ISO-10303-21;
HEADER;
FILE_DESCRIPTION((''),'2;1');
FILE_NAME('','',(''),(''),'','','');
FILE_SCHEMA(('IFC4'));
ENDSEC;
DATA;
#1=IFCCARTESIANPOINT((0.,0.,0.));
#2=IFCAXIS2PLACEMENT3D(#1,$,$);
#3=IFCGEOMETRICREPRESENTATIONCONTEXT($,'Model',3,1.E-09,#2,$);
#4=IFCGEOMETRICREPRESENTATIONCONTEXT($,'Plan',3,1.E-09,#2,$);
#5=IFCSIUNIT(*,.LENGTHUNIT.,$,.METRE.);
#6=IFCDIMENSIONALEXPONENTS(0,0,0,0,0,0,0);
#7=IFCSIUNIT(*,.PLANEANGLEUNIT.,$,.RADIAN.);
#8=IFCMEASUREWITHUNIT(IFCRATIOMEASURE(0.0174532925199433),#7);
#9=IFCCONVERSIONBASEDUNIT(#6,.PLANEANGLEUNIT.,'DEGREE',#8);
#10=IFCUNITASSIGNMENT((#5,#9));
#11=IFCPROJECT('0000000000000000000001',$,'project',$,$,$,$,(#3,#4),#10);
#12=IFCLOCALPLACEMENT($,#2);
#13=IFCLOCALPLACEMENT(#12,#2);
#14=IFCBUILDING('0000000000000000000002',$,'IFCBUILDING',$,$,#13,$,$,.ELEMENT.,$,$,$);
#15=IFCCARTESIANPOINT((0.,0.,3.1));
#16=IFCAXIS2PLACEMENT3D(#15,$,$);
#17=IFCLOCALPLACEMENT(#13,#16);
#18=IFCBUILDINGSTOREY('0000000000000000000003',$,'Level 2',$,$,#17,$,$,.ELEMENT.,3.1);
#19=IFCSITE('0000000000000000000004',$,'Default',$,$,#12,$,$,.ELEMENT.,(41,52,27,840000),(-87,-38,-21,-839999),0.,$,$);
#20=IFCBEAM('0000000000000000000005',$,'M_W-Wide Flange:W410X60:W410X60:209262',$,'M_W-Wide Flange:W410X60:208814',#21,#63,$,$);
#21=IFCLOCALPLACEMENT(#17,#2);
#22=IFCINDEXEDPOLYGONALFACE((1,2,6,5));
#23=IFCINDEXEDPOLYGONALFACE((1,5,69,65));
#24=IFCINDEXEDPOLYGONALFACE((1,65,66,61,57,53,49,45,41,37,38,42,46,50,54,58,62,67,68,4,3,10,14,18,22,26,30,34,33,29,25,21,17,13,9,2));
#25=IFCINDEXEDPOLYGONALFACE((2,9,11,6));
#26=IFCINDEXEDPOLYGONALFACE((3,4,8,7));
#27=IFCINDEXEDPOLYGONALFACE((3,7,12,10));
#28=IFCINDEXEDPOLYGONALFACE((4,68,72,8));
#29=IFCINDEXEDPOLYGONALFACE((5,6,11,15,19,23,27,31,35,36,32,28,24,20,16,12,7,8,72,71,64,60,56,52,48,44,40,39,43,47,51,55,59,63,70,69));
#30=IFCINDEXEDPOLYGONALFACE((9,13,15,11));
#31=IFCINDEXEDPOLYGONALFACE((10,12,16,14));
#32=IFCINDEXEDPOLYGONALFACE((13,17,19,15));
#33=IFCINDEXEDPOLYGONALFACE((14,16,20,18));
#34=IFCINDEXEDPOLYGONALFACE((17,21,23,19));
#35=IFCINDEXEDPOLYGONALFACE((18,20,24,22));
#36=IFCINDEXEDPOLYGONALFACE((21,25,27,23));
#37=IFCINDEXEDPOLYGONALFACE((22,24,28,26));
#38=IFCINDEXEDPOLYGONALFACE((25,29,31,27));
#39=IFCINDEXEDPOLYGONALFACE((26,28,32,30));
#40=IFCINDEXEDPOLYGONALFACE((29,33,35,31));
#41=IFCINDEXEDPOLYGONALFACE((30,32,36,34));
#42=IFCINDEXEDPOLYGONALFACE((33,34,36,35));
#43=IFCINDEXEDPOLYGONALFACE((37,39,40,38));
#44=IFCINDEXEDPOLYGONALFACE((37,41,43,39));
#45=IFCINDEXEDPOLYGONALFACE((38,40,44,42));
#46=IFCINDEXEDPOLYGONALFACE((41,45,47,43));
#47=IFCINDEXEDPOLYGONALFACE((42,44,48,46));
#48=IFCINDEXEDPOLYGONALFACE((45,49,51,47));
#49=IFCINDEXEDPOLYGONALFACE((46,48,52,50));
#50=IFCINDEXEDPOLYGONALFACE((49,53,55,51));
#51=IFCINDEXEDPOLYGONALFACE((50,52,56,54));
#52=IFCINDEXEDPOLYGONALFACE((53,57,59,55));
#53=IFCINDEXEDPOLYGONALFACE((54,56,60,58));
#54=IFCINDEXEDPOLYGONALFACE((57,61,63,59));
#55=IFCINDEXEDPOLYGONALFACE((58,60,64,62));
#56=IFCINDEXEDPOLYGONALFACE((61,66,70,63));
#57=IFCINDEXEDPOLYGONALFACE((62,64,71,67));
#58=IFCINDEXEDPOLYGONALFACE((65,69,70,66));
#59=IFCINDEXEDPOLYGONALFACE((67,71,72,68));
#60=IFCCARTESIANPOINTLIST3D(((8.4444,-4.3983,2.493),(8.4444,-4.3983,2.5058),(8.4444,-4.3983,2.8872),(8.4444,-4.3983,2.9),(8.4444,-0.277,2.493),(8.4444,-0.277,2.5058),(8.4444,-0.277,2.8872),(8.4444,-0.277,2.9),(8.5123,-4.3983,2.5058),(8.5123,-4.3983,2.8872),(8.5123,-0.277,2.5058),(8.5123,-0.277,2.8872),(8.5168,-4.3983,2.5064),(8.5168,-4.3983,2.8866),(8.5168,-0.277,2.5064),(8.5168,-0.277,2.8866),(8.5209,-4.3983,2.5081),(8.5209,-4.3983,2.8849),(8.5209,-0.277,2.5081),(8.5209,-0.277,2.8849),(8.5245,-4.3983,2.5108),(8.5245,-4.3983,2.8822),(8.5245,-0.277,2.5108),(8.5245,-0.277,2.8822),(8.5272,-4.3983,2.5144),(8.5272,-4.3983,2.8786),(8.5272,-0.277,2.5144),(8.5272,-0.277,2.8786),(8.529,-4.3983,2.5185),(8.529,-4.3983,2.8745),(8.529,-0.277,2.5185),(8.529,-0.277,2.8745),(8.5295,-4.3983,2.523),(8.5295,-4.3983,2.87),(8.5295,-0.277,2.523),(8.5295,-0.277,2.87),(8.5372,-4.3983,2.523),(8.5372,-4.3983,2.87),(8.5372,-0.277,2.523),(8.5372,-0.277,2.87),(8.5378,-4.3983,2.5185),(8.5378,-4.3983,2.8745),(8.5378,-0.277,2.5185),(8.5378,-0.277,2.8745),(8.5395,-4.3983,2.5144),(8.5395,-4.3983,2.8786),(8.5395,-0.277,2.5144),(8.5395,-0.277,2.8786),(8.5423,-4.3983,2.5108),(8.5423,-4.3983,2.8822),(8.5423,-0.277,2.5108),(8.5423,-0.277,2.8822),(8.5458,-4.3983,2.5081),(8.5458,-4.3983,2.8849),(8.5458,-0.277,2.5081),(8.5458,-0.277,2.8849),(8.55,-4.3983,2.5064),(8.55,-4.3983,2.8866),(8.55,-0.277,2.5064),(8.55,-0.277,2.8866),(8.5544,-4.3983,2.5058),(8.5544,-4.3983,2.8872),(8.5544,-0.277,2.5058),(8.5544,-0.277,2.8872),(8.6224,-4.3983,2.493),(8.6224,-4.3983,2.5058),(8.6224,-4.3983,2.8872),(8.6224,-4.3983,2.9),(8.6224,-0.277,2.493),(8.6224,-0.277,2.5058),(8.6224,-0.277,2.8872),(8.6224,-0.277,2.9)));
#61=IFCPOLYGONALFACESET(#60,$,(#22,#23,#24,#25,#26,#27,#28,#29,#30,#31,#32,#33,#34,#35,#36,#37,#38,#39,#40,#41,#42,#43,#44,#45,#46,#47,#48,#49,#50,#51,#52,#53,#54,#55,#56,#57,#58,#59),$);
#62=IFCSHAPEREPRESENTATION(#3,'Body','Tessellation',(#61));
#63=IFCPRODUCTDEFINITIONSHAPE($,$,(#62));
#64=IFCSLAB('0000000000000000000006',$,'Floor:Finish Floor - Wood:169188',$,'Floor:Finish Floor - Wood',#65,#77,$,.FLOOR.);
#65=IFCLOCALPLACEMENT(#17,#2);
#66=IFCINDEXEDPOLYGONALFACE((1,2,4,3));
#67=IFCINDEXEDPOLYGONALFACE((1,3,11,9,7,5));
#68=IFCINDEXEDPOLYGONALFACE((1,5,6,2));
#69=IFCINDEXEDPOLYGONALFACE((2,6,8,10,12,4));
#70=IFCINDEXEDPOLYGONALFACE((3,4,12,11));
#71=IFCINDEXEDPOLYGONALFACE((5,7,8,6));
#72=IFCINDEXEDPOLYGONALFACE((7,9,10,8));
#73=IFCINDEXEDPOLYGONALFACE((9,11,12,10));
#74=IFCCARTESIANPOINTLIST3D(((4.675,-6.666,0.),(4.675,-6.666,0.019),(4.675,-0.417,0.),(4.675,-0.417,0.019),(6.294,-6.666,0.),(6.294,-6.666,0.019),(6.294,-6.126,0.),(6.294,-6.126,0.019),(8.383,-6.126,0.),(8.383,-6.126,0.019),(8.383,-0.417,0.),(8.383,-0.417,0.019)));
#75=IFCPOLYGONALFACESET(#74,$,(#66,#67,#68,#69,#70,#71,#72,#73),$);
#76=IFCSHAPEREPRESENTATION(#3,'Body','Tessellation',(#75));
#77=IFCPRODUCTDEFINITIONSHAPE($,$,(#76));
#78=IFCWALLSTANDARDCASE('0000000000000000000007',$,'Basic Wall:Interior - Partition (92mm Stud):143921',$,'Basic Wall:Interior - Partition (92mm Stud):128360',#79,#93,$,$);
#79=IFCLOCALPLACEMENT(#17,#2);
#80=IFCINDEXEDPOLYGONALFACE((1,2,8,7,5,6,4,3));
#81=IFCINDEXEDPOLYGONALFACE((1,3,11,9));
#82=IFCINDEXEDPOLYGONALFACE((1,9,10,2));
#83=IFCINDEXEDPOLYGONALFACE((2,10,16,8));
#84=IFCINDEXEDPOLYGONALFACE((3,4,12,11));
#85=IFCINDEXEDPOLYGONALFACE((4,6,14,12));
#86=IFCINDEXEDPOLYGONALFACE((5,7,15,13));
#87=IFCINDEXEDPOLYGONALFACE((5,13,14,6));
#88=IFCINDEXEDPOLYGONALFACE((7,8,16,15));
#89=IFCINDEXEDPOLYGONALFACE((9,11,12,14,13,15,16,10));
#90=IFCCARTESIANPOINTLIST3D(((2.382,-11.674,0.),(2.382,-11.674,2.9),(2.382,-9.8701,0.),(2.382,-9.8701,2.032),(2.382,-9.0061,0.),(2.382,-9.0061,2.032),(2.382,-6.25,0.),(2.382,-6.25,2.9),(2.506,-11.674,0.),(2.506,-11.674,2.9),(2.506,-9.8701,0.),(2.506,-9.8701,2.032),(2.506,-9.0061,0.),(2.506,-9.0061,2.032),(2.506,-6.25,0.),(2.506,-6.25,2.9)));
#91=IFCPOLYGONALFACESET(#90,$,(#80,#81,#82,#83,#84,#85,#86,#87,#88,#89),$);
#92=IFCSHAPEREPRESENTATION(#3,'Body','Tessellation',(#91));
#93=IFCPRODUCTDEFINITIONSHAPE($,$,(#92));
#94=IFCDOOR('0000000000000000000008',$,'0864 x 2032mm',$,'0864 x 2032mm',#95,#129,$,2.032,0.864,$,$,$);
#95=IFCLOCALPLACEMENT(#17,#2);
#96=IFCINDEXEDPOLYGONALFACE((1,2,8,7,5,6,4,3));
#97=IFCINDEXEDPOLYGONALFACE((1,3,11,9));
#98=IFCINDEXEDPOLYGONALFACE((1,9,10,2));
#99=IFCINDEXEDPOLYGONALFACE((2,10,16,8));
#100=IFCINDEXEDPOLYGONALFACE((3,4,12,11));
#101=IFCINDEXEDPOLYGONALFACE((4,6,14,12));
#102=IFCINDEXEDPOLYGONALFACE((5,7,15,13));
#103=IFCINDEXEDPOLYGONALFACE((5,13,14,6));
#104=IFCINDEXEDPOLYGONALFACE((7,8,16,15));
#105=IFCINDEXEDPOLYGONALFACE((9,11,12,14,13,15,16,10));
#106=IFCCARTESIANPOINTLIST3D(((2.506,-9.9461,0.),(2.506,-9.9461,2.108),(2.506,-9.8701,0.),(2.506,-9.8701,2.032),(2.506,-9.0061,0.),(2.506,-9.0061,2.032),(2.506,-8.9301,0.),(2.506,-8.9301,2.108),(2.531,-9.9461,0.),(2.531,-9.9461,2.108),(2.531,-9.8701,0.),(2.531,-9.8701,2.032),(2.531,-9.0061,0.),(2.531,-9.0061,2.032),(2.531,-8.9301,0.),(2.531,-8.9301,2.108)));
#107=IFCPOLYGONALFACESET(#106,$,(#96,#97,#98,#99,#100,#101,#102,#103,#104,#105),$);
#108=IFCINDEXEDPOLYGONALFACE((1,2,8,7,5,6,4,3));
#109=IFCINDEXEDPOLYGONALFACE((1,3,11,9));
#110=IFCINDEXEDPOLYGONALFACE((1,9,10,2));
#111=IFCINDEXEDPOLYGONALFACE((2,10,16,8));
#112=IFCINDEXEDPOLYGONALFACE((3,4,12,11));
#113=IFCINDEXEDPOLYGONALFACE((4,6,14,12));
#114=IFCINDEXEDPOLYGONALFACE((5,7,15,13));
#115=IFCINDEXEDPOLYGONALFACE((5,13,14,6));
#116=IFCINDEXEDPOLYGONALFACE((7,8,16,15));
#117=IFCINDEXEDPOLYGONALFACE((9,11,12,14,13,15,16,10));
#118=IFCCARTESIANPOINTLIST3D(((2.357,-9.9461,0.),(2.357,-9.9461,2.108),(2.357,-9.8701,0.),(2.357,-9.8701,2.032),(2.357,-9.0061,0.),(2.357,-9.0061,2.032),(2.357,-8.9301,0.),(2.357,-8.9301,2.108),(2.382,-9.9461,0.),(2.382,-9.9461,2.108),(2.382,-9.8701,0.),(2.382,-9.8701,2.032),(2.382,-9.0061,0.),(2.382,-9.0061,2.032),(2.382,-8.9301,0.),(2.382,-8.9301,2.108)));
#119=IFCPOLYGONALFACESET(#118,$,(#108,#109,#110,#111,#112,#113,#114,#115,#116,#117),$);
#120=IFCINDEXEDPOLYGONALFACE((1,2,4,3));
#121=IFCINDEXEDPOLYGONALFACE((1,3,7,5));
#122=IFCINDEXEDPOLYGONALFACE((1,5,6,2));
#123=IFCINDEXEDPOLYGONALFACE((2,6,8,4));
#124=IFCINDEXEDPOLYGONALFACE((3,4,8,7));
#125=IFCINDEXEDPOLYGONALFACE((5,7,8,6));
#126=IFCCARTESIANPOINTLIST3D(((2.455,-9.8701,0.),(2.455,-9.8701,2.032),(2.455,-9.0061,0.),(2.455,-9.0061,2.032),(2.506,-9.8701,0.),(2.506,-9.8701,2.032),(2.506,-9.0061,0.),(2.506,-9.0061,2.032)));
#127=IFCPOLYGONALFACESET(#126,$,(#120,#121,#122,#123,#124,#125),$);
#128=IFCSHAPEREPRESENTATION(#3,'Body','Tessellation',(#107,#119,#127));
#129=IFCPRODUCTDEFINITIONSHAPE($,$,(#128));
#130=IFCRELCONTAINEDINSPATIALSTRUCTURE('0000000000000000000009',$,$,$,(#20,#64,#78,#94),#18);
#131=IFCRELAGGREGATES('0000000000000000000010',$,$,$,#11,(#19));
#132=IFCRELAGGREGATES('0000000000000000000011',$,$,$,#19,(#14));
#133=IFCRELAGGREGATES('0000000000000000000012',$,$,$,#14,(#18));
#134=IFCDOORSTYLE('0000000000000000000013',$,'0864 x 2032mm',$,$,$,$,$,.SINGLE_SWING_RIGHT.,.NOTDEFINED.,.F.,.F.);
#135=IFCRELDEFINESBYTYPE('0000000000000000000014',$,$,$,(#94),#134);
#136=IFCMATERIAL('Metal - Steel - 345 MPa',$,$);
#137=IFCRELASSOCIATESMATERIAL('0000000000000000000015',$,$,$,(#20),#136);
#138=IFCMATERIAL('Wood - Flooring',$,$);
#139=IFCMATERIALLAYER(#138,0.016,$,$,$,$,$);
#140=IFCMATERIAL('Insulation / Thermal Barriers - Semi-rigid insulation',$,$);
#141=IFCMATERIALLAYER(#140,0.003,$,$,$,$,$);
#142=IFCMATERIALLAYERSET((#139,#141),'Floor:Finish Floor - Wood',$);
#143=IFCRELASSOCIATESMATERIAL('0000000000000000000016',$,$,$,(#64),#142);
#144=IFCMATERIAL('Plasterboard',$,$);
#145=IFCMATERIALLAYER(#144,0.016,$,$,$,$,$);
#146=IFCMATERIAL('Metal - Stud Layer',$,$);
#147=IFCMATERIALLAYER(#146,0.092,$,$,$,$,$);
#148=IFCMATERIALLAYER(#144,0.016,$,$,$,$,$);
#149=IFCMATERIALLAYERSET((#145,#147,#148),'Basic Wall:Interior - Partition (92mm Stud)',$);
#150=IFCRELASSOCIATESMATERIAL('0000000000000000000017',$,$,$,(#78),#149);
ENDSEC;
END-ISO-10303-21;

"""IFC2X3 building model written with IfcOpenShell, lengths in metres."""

from ifc_helpers import new_model, entity, si_unit, converted_unit, frame, frame_2d, origin, origin_2d_with_axis, place, context, project, spatial, polyline, circle_curve, parameter, trimmed, segment, composite_curve, rectangle, outline, extrude, source, transform, mapped, material, layer, layer_set, layer_usage, type_object, type_shapes, element, fill, save


model = new_model("IFC2X3")

# Units and contexts
model_context = context("Model", 3, precision=1e-09, world=origin())
plan_context = context("Plan", 3, precision=1e-09, world=origin())
ifc_project = project(units=[si_unit("LENGTHUNIT", "METRE"), converted_unit("PLANEANGLEUNIT", "DEGREE", entity("IfcRatioMeasure", 0.0174532925199433), si_unit("PLANEANGLEUNIT", "RADIAN"), dimensions=[0, 0, 0, 0, 0, 0, 0])], contexts=[model_context, plan_context])

# Site, building, storey
site_placement = place(None, origin())
site = spatial("IfcSite", under=ifc_project, at=site_placement, Name="Default", CompositionType="ELEMENT", RefLatitude=(41, 52, 27, 840000), RefLongitude=(-87, -38, -21, -839999), RefElevation=0.0)
building_placement = place(site_placement, origin())
building = spatial("IfcBuilding", under=site, at=building_placement, Name="IFCBUILDING", CompositionType="ELEMENT")
storey_placement = place(building_placement, frame((0.0, 0.0, 3.1)))
storey = spatial("IfcBuildingStorey", under=building, at=storey_placement, Name="Level 2", CompositionType="ELEMENT", Elevation=3.1)

# Beam
ifc_material_1 = material(Name="Metal - Steel - 345 MPa")
beam_1_placement = place(storey_placement, frame((8.5334, -4.3983, 2.9)))
element("IfcBeam", 1, at=beam_1_placement, inside=storey, material=ifc_material_1, Name="M_W-Wide Flange:W410X60:W410X60:209262", ObjectType="M_W-Wide Flange:W410X60:208814", context=model_context, shape_type="SweptSolid", body=[
    extrude(outline(composite_curve([segment(polyline([(-0.089, -0.1907), (-0.089, -0.2035)]), True, "CONTINUOUS"), segment(polyline([(-0.089, -0.2035), (0.089, -0.2035)]), True, "CONTINUOUS"), segment(polyline([(0.089, -0.2035), (0.089, -0.1907)]), True, "CONTINUOUS"), segment(polyline([(0.089, -0.1907), (0.021, -0.1907)]), True, "CONTINUOUS"), segment(trimmed(circle_curve(frame_2d((0.021, -0.1735), x_axis=(0.0, -1.0)), 0.0172), [parameter(270.0)], [parameter(360.0)], True, "PARAMETER"), False, "CONTINUOUS"), segment(polyline([(0.0038, -0.1735), (0.0038, 0.1735)]), True, "CONTINUOUS"), segment(trimmed(circle_curve(frame_2d((0.021, 0.1735), x_axis=(-1.0, 0.0)), 0.0172), [parameter(270.0)], [parameter(360.0)], True, "PARAMETER"), False, "CONTINUOUS"), segment(polyline([(0.021, 0.1907), (0.089, 0.1907)]), True, "CONTINUOUS"), segment(polyline([(0.089, 0.1907), (0.089, 0.2035)]), True, "CONTINUOUS"), segment(polyline([(0.089, 0.2035), (-0.089, 0.2035)]), True, "CONTINUOUS"), segment(polyline([(-0.089, 0.2035), (-0.089, 0.1907)]), True, "CONTINUOUS"), segment(polyline([(-0.089, 0.1907), (-0.0211, 0.1907)]), True, "CONTINUOUS"), segment(trimmed(circle_curve(frame_2d((-0.0211, 0.1735), x_axis=(0.0, 1.0)), 0.0172), [parameter(270.0)], [parameter(0.0)], True, "PARAMETER"), False, "CONTINUOUS"), segment(polyline([(-0.0039, 0.1735), (-0.0039, -0.1735)]), True, "CONTINUOUS"), segment(trimmed(circle_curve(frame_2d((-0.0211, -0.1735), x_axis=(1.0, 0.0)), 0.0172), [parameter(270.0)], [parameter(0.0)], True, "PARAMETER"), False, "CONTINUOUS"), segment(polyline([(-0.0211, -0.1907), (-0.089, -0.1907)]), True, "CONTINUOUS")], self_intersect=False)), frame((0.0, 0.0, -0.2035), z_axis=(0.0, -1.0, 0.0), x_axis=(1.0, 0.0, 0.0)), (0.0, 0.0, -1.0), 4.1213),
])

# Slab
ifc_material_2 = material(Name="Wood - Flooring")
ifc_layer_1 = layer(ifc_material_2, 0.016)
ifc_material_3 = material(Name="Insulation / Thermal Barriers - Semi-rigid insulation")
ifc_layer_2 = layer(ifc_material_3, 0.003)
ifc_layer_set_1 = layer_set([ifc_layer_1, ifc_layer_2], Name="Floor:Finish Floor - Wood")
ifc_layer_usage_1 = layer_usage(ifc_layer_set_1, "AXIS3", "POSITIVE", 0.0)
slab_placement = place(storey_placement, frame((4.675, -6.666, 0.0)))
element("IfcSlab", 2, at=slab_placement, inside=storey, material=ifc_layer_usage_1, Name="Floor:Finish Floor - Wood:169188", ObjectType="Floor:Finish Floor - Wood", PredefinedType="FLOOR", context=model_context, shape_type="SweptSolid", body=[
    extrude(outline(polyline([(-1.854, 3.1245), (-1.854, -2.5845), (0.235, -2.5845), (0.235, -3.1245), (1.854, -3.1245), (1.854, 3.1245), (-1.854, 3.1245)])), frame((1.854, 3.1245, 0.019), z_axis=(0.0, 0.0, -1.0), x_axis=(-1.0, 0.0, 0.0)), (0.0, 0.0, 1.0), 0.019),
])

# Shared definitions
ifc_material_4 = material(Name="Metal - Stud Layer")
ifc_material_5 = material(Name="Plasterboard")

# Wall, opening, door
ifc_layer_3 = layer(ifc_material_5, 0.016)
ifc_layer_4 = layer(ifc_material_4, 0.092)
ifc_layer_5 = layer(ifc_material_5, 0.016)
ifc_layer_set_2 = layer_set([ifc_layer_3, ifc_layer_4, ifc_layer_5], Name="Basic Wall:Interior - Partition (92mm Stud)")
ifc_layer_usage_2 = layer_usage(ifc_layer_set_2, "AXIS2", "NEGATIVE", 0.062)
wall_1_placement = place(storey_placement, frame((2.444, -6.25, 0.0), z_axis=(0.0, 0.0, 1.0), x_axis=(0.0, -1.0, 0.0)))
wall_1 = element("IfcWallStandardCase", 3, at=wall_1_placement, inside=storey, material=ifc_layer_usage_2, Name="Basic Wall:Interior - Partition (92mm Stud):143921", ObjectType="Basic Wall:Interior - Partition (92mm Stud):128360", context=model_context, shape_type="SweptSolid", body=[
    extrude(rectangle(XDim=5.424, YDim=0.124, at=frame_2d((2.712, 0.0), x_axis=(-1.0, 0.0))), origin(), (0.0, 0.0, 1.0), 2.9),
])
opening_1_placement = place(wall_1_placement, frame((2.7561, -0.062, 0.0)))
opening_1 = element("IfcOpeningElement", 4, at=opening_1_placement, cuts=wall_1, ObjectType="Opening", context=model_context, shape_type="SweptSolid", body=[
    extrude(rectangle(XDim=0.864, YDim=2.032, at=frame_2d((1.016, 0.432), x_axis=(0.0, 1.0))), frame((0.0, 0.0, 0.0), z_axis=(0.0, 1.0, 0.0), x_axis=(0.0, 0.0, 1.0)), (0.0, 0.0, 1.0), 0.124),
])
door_style_1 = type_object("IfcDoorStyle", Name="0864 x 2032mm", ConstructionType="NOTDEFINED", OperationType="SINGLE_SWING_RIGHT", ParameterTakesPrecedence=False, Sizeable=False)
shared_shape_1 = source(origin(), model_context, "Body", "SweptSolid", [
    extrude(outline(polyline([(-0.508, -1.073), (0.508, -1.073), (0.508, 1.035), (0.432, 1.035), (0.432, -0.997), (-0.432, -0.997), (-0.432, 1.035), (-0.508, 1.035), (-0.508, -1.073)])), frame((0.432, 0.124, 1.035), z_axis=(0.0, 1.0, 0.0), x_axis=(1.0, 0.0, 0.0)), (0.0, 0.0, 1.0), 0.025),
    extrude(outline(polyline([(-1.073, -0.508), (1.035, -0.508), (1.035, -0.432), (-0.997, -0.432), (-0.997, 0.432), (1.035, 0.432), (1.035, 0.508), (-1.073, 0.508), (-1.073, -0.508)])), frame((0.432, -0.025, 1.035), z_axis=(0.0, 1.0, 0.0), x_axis=(0.0, 0.0, -1.0)), (0.0, 0.0, 1.0), 0.025),
    extrude(rectangle(XDim=0.051, YDim=0.864, at=origin_2d_with_axis()), frame((0.432, 0.0985, 0.0), z_axis=(0.0, 0.0, 1.0), x_axis=(0.0, 1.0, 0.0)), (0.0, 0.0, 1.0), 2.032),
])
type_shapes(door_style_1, [shared_shape_1])
door_1_placement = place(opening_1_placement, origin())
door_1 = element("IfcDoor", 5, at=door_1_placement, inside=storey, type_object=door_style_1, Name="0864 x 2032mm", ObjectType="0864 x 2032mm", OverallHeight=2.032, OverallWidth=0.864, context=model_context, shape_type="MappedRepresentation", body=[
    mapped(shared_shape_1, transform((0.0, 0.0, 0.0), scale=1.0)),
])
fill(opening_1, door_1)

save(model, "model.ifc")
